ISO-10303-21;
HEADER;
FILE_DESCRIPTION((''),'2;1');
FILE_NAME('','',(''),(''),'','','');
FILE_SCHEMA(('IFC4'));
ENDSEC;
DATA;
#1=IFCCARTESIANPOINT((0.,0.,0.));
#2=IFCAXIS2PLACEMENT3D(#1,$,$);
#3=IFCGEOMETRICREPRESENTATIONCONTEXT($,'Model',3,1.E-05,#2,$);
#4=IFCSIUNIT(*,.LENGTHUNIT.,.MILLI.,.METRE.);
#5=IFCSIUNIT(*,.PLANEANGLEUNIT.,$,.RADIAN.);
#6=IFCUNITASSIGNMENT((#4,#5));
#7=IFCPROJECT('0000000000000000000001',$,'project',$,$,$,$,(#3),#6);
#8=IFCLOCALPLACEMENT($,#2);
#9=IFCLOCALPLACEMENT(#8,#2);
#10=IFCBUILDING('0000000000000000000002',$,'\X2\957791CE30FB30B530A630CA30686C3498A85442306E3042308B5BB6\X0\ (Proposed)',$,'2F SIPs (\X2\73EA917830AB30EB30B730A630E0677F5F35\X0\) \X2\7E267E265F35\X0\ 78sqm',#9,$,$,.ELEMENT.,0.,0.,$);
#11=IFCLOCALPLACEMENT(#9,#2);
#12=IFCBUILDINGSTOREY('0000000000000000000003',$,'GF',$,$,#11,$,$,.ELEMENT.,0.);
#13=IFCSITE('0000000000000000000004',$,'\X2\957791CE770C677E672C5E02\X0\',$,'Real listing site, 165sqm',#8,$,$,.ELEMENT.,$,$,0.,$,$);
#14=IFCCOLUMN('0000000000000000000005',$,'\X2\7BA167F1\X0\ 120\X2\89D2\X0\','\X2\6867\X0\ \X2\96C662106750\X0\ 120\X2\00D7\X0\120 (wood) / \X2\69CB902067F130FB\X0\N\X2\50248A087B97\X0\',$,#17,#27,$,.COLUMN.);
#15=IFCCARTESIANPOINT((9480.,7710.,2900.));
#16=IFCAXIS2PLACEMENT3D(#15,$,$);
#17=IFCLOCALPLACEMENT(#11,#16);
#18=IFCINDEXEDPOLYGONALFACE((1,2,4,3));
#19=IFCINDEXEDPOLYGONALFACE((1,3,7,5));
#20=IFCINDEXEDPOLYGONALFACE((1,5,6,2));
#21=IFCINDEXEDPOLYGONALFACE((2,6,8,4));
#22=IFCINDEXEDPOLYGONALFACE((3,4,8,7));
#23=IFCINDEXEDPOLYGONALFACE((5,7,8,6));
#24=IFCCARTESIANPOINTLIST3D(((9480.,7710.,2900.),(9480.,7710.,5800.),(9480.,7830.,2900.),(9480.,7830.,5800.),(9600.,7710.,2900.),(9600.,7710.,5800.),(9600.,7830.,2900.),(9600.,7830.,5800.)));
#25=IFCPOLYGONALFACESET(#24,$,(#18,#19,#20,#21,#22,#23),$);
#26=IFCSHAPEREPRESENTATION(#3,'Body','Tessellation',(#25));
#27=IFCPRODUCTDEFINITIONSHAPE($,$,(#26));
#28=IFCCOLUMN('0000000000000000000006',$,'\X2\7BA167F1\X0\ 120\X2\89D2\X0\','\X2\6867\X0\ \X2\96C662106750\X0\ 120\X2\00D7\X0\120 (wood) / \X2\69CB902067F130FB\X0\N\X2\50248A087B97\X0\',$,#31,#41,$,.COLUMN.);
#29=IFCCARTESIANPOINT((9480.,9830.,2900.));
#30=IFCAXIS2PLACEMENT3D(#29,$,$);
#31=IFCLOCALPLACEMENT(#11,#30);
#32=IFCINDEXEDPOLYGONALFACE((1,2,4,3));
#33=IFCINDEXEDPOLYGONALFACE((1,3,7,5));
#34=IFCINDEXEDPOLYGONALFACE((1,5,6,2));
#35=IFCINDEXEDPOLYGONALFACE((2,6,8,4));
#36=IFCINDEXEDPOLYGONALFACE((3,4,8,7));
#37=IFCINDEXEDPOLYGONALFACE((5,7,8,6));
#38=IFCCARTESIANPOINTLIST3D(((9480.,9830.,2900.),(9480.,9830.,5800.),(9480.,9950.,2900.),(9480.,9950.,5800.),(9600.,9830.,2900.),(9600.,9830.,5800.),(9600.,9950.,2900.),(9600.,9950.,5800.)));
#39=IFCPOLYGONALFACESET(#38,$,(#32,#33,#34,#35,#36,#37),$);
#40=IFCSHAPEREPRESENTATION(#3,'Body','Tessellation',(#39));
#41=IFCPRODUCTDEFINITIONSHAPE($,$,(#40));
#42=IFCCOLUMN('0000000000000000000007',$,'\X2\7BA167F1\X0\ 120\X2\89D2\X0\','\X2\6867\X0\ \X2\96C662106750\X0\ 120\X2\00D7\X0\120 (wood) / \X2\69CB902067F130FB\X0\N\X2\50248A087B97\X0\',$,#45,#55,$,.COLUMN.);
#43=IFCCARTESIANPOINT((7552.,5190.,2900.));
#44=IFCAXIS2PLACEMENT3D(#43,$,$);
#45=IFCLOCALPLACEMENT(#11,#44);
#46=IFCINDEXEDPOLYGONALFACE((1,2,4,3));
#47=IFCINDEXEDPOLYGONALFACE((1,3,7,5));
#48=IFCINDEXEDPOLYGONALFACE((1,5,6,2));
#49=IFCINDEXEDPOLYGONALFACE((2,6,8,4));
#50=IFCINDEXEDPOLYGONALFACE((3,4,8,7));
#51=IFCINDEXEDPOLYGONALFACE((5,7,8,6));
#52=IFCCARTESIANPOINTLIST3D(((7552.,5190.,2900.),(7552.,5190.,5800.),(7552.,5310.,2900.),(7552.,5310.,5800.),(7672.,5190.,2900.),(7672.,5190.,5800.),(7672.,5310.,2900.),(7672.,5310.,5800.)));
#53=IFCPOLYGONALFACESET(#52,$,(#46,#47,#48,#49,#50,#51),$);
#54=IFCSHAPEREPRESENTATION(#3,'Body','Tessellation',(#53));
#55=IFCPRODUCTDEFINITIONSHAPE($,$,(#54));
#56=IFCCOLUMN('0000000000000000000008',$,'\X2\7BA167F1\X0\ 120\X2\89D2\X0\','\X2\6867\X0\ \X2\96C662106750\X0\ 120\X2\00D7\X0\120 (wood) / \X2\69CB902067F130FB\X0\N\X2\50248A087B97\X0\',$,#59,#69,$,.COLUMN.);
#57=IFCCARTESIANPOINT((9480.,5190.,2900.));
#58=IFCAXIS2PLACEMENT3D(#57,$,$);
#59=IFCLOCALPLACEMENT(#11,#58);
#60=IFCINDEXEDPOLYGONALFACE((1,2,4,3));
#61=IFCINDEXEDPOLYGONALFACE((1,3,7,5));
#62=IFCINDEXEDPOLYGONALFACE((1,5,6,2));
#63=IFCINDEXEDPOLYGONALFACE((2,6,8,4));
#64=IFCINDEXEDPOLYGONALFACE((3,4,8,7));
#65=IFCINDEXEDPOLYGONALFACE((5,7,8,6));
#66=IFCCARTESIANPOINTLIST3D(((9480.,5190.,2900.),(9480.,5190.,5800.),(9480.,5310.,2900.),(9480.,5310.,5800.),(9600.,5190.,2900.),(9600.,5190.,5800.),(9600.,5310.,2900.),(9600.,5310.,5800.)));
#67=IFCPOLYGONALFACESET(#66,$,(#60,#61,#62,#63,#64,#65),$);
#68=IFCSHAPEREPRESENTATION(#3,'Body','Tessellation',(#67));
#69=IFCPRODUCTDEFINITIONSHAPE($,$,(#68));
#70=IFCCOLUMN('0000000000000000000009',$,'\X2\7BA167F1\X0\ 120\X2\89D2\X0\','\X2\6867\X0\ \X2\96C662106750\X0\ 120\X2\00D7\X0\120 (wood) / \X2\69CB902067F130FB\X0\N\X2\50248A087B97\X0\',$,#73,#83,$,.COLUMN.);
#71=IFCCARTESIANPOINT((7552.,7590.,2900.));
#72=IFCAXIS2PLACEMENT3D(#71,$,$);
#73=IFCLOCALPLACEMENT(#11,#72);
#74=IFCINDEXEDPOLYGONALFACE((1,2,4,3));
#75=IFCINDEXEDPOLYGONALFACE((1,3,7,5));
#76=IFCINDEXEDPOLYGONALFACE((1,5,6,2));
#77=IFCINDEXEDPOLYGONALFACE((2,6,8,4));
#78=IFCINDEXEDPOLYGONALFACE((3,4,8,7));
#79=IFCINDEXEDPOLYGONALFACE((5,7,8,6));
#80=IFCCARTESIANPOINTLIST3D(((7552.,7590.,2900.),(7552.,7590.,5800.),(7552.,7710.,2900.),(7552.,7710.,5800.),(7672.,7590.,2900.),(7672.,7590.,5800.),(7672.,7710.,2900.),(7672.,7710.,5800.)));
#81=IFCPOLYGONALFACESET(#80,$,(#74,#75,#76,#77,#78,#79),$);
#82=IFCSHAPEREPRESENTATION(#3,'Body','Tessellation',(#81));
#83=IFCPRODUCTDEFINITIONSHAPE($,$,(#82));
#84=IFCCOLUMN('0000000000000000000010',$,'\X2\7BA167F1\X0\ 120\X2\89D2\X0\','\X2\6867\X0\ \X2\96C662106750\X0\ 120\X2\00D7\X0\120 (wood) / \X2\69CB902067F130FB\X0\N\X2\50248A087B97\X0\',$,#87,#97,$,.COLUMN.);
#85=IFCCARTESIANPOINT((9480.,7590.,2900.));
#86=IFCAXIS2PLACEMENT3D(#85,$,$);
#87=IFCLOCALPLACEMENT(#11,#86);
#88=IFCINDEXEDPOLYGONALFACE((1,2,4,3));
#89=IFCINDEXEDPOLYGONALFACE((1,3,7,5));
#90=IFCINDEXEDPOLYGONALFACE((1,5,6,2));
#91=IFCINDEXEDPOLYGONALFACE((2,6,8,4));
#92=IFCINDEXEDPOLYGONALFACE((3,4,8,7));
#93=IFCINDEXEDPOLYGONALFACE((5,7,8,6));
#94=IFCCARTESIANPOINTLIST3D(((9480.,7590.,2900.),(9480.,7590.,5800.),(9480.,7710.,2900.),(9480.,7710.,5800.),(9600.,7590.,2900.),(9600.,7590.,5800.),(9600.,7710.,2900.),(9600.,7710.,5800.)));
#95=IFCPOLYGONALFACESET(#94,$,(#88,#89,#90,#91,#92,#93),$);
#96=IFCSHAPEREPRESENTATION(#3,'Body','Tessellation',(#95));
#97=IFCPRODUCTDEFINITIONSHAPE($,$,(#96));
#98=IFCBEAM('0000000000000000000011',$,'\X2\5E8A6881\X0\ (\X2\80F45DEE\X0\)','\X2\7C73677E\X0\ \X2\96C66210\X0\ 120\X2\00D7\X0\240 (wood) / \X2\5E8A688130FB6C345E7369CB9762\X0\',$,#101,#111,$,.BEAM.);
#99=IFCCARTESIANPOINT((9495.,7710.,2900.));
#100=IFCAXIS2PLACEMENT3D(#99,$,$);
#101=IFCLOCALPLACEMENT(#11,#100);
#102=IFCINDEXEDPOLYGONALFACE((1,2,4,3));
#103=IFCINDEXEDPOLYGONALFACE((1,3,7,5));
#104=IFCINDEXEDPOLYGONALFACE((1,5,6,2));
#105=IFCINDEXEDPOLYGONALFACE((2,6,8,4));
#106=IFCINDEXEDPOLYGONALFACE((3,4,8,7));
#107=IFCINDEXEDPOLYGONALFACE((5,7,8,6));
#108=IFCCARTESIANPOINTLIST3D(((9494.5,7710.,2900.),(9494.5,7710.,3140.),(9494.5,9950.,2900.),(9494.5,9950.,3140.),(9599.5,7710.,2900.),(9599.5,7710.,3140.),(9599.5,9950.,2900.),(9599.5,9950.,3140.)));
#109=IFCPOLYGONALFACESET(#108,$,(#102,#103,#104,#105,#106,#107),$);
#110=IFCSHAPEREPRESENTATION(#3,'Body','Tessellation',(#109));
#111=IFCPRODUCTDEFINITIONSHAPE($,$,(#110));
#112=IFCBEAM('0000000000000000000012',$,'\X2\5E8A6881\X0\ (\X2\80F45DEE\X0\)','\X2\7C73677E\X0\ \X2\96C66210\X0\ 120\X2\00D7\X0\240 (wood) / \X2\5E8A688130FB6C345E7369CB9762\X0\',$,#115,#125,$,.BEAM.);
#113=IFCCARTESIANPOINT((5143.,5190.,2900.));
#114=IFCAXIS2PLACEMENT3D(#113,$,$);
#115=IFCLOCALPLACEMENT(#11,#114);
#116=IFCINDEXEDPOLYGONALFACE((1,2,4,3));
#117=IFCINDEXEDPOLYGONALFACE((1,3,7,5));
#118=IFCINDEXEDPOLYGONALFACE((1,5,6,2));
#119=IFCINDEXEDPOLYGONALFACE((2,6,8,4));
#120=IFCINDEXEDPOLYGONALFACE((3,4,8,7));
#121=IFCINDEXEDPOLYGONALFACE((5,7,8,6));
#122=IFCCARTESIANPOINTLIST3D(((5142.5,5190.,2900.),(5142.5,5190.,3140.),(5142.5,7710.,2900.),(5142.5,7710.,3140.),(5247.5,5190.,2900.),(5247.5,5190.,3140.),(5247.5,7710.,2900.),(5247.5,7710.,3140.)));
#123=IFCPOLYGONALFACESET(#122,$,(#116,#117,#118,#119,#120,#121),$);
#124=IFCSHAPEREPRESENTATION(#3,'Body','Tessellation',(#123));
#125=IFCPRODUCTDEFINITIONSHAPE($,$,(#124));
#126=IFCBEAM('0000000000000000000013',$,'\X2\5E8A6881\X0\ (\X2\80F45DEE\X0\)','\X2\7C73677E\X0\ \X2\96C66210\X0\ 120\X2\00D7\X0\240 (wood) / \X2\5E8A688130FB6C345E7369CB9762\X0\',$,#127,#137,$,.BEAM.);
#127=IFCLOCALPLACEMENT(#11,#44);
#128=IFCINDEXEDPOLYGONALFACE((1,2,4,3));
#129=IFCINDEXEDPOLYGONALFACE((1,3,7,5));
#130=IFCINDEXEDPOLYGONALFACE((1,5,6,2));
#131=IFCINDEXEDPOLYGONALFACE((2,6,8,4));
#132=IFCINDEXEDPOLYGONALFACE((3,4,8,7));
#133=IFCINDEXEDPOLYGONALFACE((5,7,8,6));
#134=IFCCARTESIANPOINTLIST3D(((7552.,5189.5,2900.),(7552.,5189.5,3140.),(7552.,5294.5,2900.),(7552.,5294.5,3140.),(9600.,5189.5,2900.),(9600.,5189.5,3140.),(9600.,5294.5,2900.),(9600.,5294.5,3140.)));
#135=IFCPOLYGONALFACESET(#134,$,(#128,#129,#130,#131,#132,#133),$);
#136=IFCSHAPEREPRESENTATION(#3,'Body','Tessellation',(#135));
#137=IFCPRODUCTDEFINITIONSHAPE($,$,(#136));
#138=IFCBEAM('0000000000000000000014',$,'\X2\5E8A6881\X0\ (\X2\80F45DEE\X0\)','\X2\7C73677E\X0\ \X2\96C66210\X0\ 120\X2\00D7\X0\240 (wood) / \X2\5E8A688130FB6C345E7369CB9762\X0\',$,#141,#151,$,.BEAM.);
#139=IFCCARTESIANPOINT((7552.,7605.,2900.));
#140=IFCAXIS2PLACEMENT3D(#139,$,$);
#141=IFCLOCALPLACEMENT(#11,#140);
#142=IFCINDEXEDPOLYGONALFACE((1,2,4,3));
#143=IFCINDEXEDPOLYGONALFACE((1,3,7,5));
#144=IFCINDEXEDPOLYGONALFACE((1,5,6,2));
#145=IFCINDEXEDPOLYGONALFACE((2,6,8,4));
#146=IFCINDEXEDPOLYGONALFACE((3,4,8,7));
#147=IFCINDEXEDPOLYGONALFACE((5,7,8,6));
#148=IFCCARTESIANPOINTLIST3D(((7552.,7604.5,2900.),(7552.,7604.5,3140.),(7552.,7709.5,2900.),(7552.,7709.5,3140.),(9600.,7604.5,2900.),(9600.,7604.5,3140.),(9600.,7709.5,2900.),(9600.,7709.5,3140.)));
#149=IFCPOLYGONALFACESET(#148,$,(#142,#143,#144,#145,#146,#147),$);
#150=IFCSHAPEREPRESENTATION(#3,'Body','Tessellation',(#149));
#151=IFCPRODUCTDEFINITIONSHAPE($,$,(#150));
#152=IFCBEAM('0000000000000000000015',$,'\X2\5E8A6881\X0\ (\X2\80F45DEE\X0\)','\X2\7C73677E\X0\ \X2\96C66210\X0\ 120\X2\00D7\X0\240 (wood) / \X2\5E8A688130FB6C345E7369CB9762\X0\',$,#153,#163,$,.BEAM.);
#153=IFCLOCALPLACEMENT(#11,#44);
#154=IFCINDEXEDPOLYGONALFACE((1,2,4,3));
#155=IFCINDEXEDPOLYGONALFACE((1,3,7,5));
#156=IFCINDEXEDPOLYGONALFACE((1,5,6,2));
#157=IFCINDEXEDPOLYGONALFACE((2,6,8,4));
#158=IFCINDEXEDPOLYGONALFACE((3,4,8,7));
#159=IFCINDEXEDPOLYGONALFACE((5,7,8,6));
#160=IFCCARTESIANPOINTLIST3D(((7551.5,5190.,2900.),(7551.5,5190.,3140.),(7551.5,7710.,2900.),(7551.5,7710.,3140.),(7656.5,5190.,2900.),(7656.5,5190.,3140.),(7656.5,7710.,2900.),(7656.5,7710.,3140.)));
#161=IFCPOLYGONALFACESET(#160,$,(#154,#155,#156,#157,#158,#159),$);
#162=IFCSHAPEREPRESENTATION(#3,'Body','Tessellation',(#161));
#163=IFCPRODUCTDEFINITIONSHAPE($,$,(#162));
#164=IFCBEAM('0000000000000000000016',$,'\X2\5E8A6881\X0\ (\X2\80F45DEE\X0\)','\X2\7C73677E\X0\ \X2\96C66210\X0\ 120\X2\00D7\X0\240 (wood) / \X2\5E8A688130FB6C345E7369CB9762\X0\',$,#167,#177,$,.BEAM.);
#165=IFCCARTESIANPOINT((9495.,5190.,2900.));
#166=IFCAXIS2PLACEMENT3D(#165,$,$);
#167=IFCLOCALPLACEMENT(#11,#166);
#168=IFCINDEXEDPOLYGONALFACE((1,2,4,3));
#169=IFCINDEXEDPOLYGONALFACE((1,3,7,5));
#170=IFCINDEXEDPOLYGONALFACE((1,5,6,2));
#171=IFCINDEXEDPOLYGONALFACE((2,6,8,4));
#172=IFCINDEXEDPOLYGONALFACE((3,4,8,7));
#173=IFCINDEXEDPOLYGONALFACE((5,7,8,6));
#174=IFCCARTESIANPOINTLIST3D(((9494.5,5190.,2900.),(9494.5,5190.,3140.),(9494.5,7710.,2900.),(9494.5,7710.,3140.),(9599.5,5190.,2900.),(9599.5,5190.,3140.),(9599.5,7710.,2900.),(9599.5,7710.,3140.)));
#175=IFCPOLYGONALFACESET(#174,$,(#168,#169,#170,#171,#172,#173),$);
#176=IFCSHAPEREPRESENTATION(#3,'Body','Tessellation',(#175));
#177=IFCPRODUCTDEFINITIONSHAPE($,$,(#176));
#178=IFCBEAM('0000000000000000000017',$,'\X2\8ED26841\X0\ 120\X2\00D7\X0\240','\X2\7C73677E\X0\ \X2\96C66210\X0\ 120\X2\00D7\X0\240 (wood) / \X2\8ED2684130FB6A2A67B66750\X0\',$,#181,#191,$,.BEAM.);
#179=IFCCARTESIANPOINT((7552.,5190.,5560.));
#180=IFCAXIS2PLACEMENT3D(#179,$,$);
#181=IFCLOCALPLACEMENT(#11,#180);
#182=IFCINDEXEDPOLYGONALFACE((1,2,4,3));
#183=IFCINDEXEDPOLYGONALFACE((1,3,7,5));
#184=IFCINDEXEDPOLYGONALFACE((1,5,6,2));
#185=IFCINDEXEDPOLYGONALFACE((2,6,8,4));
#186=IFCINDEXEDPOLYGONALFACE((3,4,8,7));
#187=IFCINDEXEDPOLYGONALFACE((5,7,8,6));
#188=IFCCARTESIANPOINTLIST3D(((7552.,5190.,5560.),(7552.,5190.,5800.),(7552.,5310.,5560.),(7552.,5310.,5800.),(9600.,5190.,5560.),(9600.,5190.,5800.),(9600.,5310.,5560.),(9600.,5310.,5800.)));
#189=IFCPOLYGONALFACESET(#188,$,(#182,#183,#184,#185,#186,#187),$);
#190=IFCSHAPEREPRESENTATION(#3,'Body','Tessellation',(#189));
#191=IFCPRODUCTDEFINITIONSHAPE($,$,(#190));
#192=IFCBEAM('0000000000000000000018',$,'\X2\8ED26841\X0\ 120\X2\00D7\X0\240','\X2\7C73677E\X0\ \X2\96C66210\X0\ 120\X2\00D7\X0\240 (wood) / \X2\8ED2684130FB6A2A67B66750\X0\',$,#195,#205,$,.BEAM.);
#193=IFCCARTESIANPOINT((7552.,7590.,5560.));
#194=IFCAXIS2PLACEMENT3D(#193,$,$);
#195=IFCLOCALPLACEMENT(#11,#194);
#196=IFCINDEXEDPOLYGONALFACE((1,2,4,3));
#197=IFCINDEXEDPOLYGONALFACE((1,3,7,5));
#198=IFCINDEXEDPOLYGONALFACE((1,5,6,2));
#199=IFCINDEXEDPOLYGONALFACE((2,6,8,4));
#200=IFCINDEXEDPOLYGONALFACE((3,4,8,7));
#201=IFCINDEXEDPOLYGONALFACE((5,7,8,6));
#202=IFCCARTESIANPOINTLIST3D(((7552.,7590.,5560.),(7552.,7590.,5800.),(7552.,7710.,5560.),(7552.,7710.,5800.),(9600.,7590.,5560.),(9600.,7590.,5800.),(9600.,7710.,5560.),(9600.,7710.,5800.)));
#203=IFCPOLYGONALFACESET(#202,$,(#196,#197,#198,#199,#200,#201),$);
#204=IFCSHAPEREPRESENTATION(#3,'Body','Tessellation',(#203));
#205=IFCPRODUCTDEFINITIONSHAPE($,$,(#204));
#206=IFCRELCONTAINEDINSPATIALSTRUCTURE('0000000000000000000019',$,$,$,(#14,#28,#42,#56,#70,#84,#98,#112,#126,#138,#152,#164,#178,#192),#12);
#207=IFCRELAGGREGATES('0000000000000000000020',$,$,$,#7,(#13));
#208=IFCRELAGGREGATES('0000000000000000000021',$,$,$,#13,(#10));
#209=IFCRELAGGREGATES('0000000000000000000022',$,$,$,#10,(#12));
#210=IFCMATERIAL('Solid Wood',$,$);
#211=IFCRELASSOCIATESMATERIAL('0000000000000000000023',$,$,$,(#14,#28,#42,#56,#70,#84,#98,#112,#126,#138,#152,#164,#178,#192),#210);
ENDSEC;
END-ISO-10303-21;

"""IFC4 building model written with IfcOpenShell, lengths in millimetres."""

from ifc_helpers import new_model, si_unit, frame, frame_2d, origin, place, context, project, spatial, rectangle, extrude, material, element, save


model = new_model("IFC4")

# Units and contexts
model_context = context("Model", 3, precision=1e-05, world=origin())
ifc_project = project(units=[si_unit("LENGTHUNIT", "METRE", prefix="MILLI"), si_unit("PLANEANGLEUNIT", "RADIAN")], contexts=[model_context])

# Site, building, storey
site_placement = place(None, origin())
site = spatial("IfcSite", under=ifc_project, at=site_placement, Name="長野県松本市", ObjectType="Real listing site, 165sqm", CompositionType="ELEMENT", RefElevation=0.0)
building_placement = place(site_placement, origin())
building = spatial("IfcBuilding", under=site, at=building_placement, Name="長野・サウナと水風呂のある家 (Proposed)", ObjectType="2F SIPs (珪酸カルシウム板張) 縦縦張 78sqm", CompositionType="ELEMENT", ElevationOfRefHeight=0.0, ElevationOfTerrain=0.0)
storey_placement = place(building_placement, origin())
storey = spatial("IfcBuildingStorey", under=building, at=storey_placement, Name="GF", CompositionType="ELEMENT", Elevation=0.0)

# Columns
ifc_material_1 = material(Name="Solid Wood")
column_1_placement = place(storey_placement, frame((9480.0, 7710.0, 2900.0)))
element("IfcColumn", 1, at=column_1_placement, inside=storey, material=ifc_material_1, Name="管柱 120角", Description="桧 集成材 120×120 (wood) / 構造柱・N値計算", PredefinedType="COLUMN", context=model_context, shape_type="SweptSolid", body=[
    extrude(rectangle(XDim=120.0, YDim=120.0, at=frame_2d((60.0, 60.0))), frame((9480.0, 7710.0, 2900.0)), (0.0, 0.0, 1.0), 2900.0),
])
column_2_placement = place(storey_placement, frame((9480.0, 9830.0, 2900.0)))
element("IfcColumn", 2, at=column_2_placement, inside=storey, material=ifc_material_1, Name="管柱 120角", Description="桧 集成材 120×120 (wood) / 構造柱・N値計算", PredefinedType="COLUMN", context=model_context, shape_type="SweptSolid", body=[
    extrude(rectangle(XDim=120.0, YDim=120.0, at=frame_2d((60.0, 60.0))), frame((9480.0, 9830.0, 2900.0)), (0.0, 0.0, 1.0), 2900.0),
])
column_3_placement = place(storey_placement, frame((7552.0, 5190.0, 2900.0)))
element("IfcColumn", 3, at=column_3_placement, inside=storey, material=ifc_material_1, Name="管柱 120角", Description="桧 集成材 120×120 (wood) / 構造柱・N値計算", PredefinedType="COLUMN", context=model_context, shape_type="SweptSolid", body=[
    extrude(rectangle(XDim=120.0, YDim=120.0, at=frame_2d((60.0, 60.0))), frame((7552.0, 5190.0, 2900.0)), (0.0, 0.0, 1.0), 2900.0),
])
column_4_placement = place(storey_placement, frame((9480.0, 5190.0, 2900.0)))
element("IfcColumn", 4, at=column_4_placement, inside=storey, material=ifc_material_1, Name="管柱 120角", Description="桧 集成材 120×120 (wood) / 構造柱・N値計算", PredefinedType="COLUMN", context=model_context, shape_type="SweptSolid", body=[
    extrude(rectangle(XDim=120.0, YDim=120.0, at=frame_2d((60.0, 60.0))), frame((9480.0, 5190.0, 2900.0)), (0.0, 0.0, 1.0), 2900.0),
])
column_5_placement = place(storey_placement, frame((7552.0, 7590.0, 2900.0)))
element("IfcColumn", 5, at=column_5_placement, inside=storey, material=ifc_material_1, Name="管柱 120角", Description="桧 集成材 120×120 (wood) / 構造柱・N値計算", PredefinedType="COLUMN", context=model_context, shape_type="SweptSolid", body=[
    extrude(rectangle(XDim=120.0, YDim=120.0, at=frame_2d((60.0, 60.0))), frame((7552.0, 7590.0, 2900.0)), (0.0, 0.0, 1.0), 2900.0),
])
column_6_placement = place(storey_placement, frame((9480.0, 7590.0, 2900.0)))
element("IfcColumn", 6, at=column_6_placement, inside=storey, material=ifc_material_1, Name="管柱 120角", Description="桧 集成材 120×120 (wood) / 構造柱・N値計算", PredefinedType="COLUMN", context=model_context, shape_type="SweptSolid", body=[
    extrude(rectangle(XDim=120.0, YDim=120.0, at=frame_2d((60.0, 60.0))), frame((9480.0, 7590.0, 2900.0)), (0.0, 0.0, 1.0), 2900.0),
])

# Beams
beam_1_placement = place(storey_placement, frame((9495.0, 7710.0, 2900.0)))
element("IfcBeam", 7, at=beam_1_placement, inside=storey, material=ifc_material_1, Name="床梁 (胴差)", Description="米松 集成 120×240 (wood) / 床梁・水平構面", PredefinedType="BEAM", context=model_context, shape_type="SweptSolid", body=[
    extrude(rectangle(XDim=105.0, YDim=2240.0, at=frame_2d((52.0, 1120.0))), frame((9495.0, 7710.0, 2900.0)), (0.0, 0.0, 1.0), 240.0),
])
beam_2_placement = place(storey_placement, frame((5143.0, 5190.0, 2900.0)))
element("IfcBeam", 8, at=beam_2_placement, inside=storey, material=ifc_material_1, Name="床梁 (胴差)", Description="米松 集成 120×240 (wood) / 床梁・水平構面", PredefinedType="BEAM", context=model_context, shape_type="SweptSolid", body=[
    extrude(rectangle(XDim=105.0, YDim=2520.0, at=frame_2d((52.0, 1260.0))), frame((5143.0, 5190.0, 2900.0)), (0.0, 0.0, 1.0), 240.0),
])
beam_3_placement = place(storey_placement, frame((7552.0, 5190.0, 2900.0)))
element("IfcBeam", 9, at=beam_3_placement, inside=storey, material=ifc_material_1, Name="床梁 (胴差)", Description="米松 集成 120×240 (wood) / 床梁・水平構面", PredefinedType="BEAM", context=model_context, shape_type="SweptSolid", body=[
    extrude(rectangle(XDim=2048.0, YDim=105.0, at=frame_2d((1024.0, 52.0))), frame((7552.0, 5190.0, 2900.0)), (0.0, 0.0, 1.0), 240.0),
])
beam_4_placement = place(storey_placement, frame((7552.0, 7605.0, 2900.0)))
element("IfcBeam", 10, at=beam_4_placement, inside=storey, material=ifc_material_1, Name="床梁 (胴差)", Description="米松 集成 120×240 (wood) / 床梁・水平構面", PredefinedType="BEAM", context=model_context, shape_type="SweptSolid", body=[
    extrude(rectangle(XDim=2048.0, YDim=105.0, at=frame_2d((1024.0, 52.0))), frame((7552.0, 7605.0, 2900.0)), (0.0, 0.0, 1.0), 240.0),
])
beam_5_placement = place(storey_placement, frame((7552.0, 5190.0, 2900.0)))
element("IfcBeam", 11, at=beam_5_placement, inside=storey, material=ifc_material_1, Name="床梁 (胴差)", Description="米松 集成 120×240 (wood) / 床梁・水平構面", PredefinedType="BEAM", context=model_context, shape_type="SweptSolid", body=[
    extrude(rectangle(XDim=105.0, YDim=2520.0, at=frame_2d((52.0, 1260.0))), frame((7552.0, 5190.0, 2900.0)), (0.0, 0.0, 1.0), 240.0),
])
beam_6_placement = place(storey_placement, frame((9495.0, 5190.0, 2900.0)))
element("IfcBeam", 12, at=beam_6_placement, inside=storey, material=ifc_material_1, Name="床梁 (胴差)", Description="米松 集成 120×240 (wood) / 床梁・水平構面", PredefinedType="BEAM", context=model_context, shape_type="SweptSolid", body=[
    extrude(rectangle(XDim=105.0, YDim=2520.0, at=frame_2d((52.0, 1260.0))), frame((9495.0, 5190.0, 2900.0)), (0.0, 0.0, 1.0), 240.0),
])
beam_7_placement = place(storey_placement, frame((7552.0, 5190.0, 5560.0)))
element("IfcBeam", 13, at=beam_7_placement, inside=storey, material=ifc_material_1, Name="軒桁 120×240", Description="米松 集成 120×240 (wood) / 軒桁・横架材", PredefinedType="BEAM", context=model_context, shape_type="SweptSolid", body=[
    extrude(rectangle(XDim=2048.0, YDim=120.0, at=frame_2d((1024.0, 60.0))), frame((7552.0, 5190.0, 5560.0)), (0.0, 0.0, 1.0), 240.0),
])
beam_8_placement = place(storey_placement, frame((7552.0, 7590.0, 5560.0)))
element("IfcBeam", 14, at=beam_8_placement, inside=storey, material=ifc_material_1, Name="軒桁 120×240", Description="米松 集成 120×240 (wood) / 軒桁・横架材", PredefinedType="BEAM", context=model_context, shape_type="SweptSolid", body=[
    extrude(rectangle(XDim=2048.0, YDim=120.0, at=frame_2d((1024.0, 60.0))), frame((7552.0, 7590.0, 5560.0)), (0.0, 0.0, 1.0), 240.0),
])

save(model, "model.ifc")
